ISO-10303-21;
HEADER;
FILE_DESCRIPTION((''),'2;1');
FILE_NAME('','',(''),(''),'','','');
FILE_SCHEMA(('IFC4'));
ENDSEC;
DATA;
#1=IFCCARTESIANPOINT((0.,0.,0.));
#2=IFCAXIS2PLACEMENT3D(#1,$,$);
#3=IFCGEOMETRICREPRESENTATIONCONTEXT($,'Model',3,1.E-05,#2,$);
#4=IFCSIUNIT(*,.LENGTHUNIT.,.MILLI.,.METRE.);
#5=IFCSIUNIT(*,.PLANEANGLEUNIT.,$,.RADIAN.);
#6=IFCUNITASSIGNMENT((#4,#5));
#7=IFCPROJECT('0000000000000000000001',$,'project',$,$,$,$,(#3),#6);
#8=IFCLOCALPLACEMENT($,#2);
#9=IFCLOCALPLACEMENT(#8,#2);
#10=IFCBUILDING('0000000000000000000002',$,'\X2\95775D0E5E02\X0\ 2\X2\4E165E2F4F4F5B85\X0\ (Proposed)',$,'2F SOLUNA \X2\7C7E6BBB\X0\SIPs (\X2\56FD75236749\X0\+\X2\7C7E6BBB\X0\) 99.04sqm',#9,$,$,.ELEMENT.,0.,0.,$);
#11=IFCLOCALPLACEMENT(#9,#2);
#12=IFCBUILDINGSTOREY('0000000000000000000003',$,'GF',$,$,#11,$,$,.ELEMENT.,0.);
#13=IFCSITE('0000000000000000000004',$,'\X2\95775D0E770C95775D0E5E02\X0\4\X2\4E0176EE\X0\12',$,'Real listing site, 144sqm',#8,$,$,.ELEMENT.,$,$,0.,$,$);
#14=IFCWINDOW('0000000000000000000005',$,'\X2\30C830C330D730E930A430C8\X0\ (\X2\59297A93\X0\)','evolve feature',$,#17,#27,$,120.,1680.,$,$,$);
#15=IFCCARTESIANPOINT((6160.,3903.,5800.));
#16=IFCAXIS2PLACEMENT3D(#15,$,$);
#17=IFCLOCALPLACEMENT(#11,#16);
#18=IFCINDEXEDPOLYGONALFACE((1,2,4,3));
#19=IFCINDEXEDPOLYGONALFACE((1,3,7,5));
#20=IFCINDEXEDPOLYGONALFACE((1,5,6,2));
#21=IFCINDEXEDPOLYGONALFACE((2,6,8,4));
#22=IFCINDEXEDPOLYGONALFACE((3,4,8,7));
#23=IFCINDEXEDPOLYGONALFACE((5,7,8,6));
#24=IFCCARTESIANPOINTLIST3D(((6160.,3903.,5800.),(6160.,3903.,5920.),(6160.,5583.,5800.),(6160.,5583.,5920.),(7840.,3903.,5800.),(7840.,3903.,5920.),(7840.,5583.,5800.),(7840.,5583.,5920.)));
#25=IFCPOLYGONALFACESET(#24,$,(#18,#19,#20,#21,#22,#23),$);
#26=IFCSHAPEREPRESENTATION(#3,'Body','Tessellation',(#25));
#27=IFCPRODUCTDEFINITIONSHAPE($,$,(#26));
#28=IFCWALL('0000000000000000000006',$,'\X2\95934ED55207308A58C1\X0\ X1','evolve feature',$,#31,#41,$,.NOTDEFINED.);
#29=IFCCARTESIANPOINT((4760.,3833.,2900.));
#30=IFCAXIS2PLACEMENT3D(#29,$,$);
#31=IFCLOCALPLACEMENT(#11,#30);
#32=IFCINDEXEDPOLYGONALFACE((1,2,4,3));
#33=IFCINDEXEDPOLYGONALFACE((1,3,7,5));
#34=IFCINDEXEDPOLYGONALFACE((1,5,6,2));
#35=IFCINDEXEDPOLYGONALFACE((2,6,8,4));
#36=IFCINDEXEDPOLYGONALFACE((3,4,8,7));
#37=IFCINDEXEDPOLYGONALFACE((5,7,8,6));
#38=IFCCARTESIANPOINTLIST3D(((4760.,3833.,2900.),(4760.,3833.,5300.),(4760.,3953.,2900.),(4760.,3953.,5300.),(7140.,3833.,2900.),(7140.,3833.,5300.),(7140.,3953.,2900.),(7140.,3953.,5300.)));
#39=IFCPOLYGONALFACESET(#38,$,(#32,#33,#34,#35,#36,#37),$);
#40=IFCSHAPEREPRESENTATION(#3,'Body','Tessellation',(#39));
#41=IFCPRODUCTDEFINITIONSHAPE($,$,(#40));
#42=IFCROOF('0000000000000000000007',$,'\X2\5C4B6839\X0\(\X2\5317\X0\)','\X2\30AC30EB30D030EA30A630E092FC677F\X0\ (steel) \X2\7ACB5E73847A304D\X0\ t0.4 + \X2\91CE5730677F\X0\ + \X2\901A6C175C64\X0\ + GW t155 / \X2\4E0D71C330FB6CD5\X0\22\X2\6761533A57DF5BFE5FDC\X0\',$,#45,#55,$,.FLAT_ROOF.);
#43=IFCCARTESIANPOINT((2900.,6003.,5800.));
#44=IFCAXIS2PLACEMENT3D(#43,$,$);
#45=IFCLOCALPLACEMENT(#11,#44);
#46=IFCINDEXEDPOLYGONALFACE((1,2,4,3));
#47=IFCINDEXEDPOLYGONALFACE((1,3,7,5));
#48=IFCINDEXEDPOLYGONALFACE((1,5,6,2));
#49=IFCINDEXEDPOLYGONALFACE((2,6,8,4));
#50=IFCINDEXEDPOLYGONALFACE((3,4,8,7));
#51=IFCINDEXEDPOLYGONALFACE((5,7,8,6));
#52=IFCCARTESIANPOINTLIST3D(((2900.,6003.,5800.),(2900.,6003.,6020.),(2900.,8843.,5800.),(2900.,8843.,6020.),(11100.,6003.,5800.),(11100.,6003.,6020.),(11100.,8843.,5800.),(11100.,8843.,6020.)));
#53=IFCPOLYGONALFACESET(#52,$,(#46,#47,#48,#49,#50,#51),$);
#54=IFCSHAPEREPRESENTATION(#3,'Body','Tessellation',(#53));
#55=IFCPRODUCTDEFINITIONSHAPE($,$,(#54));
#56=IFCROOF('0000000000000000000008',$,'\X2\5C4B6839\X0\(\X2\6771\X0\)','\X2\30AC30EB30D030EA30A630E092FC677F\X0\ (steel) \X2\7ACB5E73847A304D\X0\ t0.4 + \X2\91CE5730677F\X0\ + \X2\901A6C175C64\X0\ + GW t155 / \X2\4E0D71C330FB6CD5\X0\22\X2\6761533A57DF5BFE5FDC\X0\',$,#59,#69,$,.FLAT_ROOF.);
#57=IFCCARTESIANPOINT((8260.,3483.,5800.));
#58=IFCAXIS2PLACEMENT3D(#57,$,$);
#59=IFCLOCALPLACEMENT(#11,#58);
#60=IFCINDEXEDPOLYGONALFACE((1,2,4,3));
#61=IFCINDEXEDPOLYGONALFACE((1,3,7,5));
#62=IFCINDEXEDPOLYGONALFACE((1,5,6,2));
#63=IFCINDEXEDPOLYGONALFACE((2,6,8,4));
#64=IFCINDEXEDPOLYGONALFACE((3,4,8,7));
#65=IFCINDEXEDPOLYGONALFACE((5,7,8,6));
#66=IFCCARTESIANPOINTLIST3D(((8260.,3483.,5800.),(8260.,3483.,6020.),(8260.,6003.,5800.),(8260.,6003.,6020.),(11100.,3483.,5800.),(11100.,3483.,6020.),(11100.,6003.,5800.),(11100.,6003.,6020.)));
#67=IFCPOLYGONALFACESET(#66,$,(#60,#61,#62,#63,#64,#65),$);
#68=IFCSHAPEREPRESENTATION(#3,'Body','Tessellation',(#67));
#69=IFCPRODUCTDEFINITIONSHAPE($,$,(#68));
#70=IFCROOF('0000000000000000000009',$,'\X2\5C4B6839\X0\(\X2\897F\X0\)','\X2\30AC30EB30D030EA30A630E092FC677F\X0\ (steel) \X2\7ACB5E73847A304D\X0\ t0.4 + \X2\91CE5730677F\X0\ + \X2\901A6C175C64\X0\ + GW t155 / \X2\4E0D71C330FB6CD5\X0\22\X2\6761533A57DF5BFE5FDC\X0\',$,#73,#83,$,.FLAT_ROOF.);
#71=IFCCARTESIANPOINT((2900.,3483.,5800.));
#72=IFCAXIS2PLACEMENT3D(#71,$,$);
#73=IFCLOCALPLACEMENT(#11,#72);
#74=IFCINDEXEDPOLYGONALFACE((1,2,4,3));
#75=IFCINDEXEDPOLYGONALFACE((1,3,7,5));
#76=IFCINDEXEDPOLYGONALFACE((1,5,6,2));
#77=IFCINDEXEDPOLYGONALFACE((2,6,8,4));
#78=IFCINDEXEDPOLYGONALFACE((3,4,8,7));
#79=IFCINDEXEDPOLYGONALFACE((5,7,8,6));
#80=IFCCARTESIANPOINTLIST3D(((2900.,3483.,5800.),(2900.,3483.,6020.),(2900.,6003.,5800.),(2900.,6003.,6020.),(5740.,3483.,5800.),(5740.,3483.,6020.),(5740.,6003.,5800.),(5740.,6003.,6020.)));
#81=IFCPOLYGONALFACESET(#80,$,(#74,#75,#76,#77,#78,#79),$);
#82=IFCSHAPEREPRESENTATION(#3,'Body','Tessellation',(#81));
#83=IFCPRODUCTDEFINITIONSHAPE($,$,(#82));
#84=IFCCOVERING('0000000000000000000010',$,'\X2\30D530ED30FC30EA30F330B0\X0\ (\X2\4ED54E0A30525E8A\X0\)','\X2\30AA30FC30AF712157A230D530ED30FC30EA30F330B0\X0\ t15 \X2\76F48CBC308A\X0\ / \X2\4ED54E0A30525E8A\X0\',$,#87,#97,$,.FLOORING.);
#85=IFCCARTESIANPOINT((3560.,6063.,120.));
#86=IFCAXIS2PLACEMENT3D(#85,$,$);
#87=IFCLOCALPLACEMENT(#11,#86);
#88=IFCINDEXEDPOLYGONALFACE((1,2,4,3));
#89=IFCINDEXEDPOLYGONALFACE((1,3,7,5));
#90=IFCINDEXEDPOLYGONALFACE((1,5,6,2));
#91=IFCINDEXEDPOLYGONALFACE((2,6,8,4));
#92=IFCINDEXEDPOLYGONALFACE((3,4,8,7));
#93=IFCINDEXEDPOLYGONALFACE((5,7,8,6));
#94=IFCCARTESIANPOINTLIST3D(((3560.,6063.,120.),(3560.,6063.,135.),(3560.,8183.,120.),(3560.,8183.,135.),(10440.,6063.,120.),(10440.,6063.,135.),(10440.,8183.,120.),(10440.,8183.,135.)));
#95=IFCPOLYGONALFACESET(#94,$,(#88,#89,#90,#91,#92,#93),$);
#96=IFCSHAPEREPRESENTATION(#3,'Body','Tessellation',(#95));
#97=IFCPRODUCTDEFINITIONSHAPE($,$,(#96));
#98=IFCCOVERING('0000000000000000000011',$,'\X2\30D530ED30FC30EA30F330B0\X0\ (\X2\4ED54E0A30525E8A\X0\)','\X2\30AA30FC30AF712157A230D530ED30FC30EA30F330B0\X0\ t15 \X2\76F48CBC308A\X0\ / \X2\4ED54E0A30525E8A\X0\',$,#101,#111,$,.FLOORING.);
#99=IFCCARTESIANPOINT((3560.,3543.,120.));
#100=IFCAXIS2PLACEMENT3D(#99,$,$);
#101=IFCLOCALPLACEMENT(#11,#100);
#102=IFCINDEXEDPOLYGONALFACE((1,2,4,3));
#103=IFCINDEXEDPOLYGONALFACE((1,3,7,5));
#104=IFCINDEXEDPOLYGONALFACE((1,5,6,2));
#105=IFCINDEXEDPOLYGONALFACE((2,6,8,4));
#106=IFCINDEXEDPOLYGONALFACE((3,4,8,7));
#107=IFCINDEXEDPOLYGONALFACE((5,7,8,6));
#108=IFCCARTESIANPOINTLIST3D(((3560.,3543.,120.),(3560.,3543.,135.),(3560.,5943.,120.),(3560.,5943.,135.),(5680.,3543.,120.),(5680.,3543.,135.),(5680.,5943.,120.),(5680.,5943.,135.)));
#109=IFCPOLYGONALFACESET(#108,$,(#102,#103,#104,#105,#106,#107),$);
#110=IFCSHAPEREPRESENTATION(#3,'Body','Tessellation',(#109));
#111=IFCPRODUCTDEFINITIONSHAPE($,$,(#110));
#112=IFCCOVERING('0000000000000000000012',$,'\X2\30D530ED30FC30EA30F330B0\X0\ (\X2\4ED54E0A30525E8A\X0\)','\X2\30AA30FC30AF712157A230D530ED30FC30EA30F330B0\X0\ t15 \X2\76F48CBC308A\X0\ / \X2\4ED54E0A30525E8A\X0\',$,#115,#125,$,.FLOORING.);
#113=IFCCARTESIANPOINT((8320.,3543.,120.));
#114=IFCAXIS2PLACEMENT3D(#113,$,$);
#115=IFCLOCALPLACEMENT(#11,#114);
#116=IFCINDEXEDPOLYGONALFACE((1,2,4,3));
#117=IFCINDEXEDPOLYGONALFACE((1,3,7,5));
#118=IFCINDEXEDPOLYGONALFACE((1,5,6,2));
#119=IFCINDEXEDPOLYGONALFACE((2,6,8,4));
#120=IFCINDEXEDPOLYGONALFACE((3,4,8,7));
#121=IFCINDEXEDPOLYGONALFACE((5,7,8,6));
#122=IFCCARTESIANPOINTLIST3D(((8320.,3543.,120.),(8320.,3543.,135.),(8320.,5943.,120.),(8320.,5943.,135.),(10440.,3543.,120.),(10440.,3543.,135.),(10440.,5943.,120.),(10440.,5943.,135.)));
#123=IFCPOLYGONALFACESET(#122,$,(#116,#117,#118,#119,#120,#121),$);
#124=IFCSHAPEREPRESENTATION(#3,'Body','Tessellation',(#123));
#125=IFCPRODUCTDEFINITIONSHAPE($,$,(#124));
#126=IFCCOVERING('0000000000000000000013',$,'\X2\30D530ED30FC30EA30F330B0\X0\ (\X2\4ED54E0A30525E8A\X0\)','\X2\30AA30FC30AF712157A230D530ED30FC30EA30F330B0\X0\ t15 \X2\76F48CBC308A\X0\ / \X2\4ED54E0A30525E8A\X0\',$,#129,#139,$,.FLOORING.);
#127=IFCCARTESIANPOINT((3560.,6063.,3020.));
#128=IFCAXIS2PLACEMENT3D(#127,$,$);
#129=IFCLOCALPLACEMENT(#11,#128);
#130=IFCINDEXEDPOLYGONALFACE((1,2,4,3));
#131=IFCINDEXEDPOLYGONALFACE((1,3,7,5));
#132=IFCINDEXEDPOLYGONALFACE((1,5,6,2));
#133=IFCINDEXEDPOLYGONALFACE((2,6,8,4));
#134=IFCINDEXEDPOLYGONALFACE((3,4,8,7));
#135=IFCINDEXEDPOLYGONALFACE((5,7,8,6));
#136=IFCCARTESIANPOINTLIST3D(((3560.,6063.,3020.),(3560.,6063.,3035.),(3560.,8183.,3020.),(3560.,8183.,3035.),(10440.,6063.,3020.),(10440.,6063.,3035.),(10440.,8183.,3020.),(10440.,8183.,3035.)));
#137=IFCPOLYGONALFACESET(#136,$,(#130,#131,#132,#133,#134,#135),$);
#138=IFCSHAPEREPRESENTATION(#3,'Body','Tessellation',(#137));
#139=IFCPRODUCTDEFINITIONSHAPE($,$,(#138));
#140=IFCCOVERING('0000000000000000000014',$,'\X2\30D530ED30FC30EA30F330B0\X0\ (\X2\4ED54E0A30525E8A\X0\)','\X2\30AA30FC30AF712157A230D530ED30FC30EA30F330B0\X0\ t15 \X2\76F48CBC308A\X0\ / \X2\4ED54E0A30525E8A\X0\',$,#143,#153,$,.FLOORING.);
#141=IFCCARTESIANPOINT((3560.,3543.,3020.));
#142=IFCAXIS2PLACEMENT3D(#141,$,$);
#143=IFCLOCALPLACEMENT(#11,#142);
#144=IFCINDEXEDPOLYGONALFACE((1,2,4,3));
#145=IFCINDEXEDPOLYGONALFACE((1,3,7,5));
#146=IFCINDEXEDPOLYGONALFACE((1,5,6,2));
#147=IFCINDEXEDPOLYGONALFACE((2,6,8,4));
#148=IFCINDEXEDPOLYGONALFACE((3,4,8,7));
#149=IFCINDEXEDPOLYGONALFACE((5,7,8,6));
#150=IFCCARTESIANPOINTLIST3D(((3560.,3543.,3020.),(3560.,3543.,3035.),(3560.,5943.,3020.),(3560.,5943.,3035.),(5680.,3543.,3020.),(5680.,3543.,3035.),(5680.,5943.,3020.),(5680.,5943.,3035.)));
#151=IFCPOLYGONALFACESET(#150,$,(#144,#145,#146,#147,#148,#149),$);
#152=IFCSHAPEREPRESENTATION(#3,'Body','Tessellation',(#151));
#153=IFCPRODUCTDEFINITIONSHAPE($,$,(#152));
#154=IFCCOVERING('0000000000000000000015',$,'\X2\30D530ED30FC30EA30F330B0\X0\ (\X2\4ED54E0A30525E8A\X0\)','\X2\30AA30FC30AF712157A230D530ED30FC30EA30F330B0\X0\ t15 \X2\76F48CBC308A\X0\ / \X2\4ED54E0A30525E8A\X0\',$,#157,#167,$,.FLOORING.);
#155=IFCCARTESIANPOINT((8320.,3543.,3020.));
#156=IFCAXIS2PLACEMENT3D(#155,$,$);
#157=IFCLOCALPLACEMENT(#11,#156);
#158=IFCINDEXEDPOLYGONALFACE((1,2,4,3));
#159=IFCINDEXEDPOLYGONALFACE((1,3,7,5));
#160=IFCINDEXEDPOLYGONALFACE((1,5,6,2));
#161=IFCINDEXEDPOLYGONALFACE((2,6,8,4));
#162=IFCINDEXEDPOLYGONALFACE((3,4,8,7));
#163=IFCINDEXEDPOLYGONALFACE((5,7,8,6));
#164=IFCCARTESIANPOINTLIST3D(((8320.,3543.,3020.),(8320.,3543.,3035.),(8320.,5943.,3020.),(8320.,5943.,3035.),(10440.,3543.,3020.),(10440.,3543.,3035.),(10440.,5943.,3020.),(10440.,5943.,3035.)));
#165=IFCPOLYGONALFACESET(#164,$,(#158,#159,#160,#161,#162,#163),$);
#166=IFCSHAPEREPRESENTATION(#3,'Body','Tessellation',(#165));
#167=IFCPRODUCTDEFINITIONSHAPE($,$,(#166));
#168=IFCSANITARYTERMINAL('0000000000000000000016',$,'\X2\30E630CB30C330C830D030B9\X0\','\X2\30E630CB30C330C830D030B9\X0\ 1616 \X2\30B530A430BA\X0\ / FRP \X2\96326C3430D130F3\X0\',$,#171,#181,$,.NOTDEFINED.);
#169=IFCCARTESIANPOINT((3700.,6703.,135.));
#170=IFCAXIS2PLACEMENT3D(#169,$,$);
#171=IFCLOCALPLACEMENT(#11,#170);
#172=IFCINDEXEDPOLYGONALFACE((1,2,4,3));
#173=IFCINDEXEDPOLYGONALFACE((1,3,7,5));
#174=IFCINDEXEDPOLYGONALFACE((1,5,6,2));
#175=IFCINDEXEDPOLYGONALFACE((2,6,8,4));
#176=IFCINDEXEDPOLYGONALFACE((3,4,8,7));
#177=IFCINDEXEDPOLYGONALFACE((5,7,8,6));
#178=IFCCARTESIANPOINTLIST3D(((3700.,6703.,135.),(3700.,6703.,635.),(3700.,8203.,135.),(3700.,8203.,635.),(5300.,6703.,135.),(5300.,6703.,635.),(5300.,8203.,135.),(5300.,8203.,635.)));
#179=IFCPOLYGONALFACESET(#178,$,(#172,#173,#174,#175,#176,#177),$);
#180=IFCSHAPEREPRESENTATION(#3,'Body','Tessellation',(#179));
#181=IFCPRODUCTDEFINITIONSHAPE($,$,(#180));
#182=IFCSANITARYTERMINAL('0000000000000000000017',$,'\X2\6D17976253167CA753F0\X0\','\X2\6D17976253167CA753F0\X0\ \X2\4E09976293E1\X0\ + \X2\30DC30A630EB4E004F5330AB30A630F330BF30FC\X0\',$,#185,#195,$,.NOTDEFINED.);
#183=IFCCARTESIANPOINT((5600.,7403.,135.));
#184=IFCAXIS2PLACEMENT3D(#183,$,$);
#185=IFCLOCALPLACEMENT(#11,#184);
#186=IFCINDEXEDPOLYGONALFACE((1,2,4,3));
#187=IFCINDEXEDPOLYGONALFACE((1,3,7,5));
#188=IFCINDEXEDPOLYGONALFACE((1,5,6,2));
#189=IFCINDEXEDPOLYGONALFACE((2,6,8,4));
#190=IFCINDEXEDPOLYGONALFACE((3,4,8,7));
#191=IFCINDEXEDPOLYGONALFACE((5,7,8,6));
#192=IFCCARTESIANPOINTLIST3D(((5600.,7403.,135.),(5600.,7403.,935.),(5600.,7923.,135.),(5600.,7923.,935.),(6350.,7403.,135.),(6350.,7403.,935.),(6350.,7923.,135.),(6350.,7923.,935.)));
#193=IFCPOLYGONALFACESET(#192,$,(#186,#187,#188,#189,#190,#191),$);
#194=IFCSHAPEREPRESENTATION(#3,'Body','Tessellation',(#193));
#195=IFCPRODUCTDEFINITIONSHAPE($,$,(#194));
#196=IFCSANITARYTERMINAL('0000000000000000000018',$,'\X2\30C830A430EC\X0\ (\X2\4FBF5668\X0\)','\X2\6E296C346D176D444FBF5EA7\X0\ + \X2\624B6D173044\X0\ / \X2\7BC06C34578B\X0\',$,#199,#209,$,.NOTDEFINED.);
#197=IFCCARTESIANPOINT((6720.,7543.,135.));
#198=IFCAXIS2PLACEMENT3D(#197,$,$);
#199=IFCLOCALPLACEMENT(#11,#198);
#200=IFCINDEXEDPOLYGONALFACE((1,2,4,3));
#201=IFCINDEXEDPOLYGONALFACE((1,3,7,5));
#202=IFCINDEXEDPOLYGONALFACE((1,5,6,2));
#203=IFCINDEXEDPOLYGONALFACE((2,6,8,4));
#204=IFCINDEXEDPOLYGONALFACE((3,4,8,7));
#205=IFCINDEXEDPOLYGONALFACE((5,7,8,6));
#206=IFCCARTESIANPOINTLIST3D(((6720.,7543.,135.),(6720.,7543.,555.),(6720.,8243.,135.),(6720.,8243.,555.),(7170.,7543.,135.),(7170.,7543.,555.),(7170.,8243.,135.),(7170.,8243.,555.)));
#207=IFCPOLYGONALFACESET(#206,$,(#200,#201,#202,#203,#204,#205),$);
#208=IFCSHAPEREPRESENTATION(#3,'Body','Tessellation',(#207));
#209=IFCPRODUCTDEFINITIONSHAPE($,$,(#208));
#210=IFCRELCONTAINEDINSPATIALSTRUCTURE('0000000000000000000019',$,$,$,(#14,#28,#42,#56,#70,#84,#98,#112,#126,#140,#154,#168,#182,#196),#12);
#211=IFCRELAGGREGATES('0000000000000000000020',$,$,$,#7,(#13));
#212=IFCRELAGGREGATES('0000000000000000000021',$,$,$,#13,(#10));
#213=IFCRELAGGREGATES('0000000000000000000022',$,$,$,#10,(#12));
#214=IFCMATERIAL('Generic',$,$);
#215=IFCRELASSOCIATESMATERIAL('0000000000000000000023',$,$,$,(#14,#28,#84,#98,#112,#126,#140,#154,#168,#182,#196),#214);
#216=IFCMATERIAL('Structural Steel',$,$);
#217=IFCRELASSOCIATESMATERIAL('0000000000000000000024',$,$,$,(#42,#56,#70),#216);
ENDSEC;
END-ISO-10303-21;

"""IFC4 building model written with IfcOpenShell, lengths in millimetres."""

from ifc_helpers import new_model, si_unit, frame, frame_2d, origin, place, context, project, spatial, rectangle, extrude, material, element, save


model = new_model("IFC4")

# Units and contexts
model_context = context("Model", 3, precision=1e-05, world=origin())
ifc_project = project(units=[si_unit("LENGTHUNIT", "METRE", prefix="MILLI"), si_unit("PLANEANGLEUNIT", "RADIAN")], contexts=[model_context])

# Site, building, storey
site_placement = place(None, origin())
site = spatial("IfcSite", under=ifc_project, at=site_placement, Name="長崎県長崎市4丁目12", ObjectType="Real listing site, 144sqm", CompositionType="ELEMENT", RefElevation=0.0)
building_placement = place(site_placement, origin())
building = spatial("IfcBuilding", under=site, at=building_placement, Name="長崎市 2世帯住宅 (Proposed)", ObjectType="2F SOLUNA 籾殻SIPs (国産杉+籾殻) 99.04sqm", CompositionType="ELEMENT", ElevationOfRefHeight=0.0, ElevationOfTerrain=0.0)
storey_placement = place(building_placement, origin())
storey = spatial("IfcBuildingStorey", under=building, at=storey_placement, Name="GF", CompositionType="ELEMENT", Elevation=0.0)

# Window
ifc_material_1 = material(Name="Generic")
window_1_placement = place(storey_placement, frame((6160.0, 3903.0, 5800.0)))
element("IfcWindow", 1, at=window_1_placement, inside=storey, material=ifc_material_1, Name="トップライト (天窓)", Description="evolve feature", OverallHeight=120.0, OverallWidth=1680.0, context=model_context, shape_type="SweptSolid", body=[
    extrude(rectangle(XDim=1680.0, YDim=1680.0, at=frame_2d((840.0, 840.0))), frame((6160.0, 3903.0, 5800.0)), (0.0, 0.0, 1.0), 120.0),
])

# Wall
wall_1_placement = place(storey_placement, frame((4760.0, 3833.0, 2900.0)))
element("IfcWall", 2, at=wall_1_placement, inside=storey, material=ifc_material_1, Name="間仕切り壁 X1", Description="evolve feature", PredefinedType="NOTDEFINED", context=model_context, shape_type="SweptSolid", body=[
    extrude(rectangle(XDim=2380.0, YDim=120.0, at=frame_2d((1190.0, 60.0))), frame((4760.0, 3833.0, 2900.0)), (0.0, 0.0, 1.0), 2400.0),
])

# Roofs
ifc_material_2 = material(Name="Structural Steel")
roof_1_placement = place(storey_placement, frame((2900.0, 6003.0, 5800.0)))
element("IfcRoof", 3, at=roof_1_placement, inside=storey, material=ifc_material_2, Name="屋根(北)", Description="ガルバリウム鋼板 (steel) 立平葺き t0.4 + 野地板 + 通気層 + GW t155 / 不燃・法22条区域対応", PredefinedType="FLAT_ROOF", context=model_context, shape_type="SweptSolid", body=[
    extrude(rectangle(XDim=8200.0, YDim=2840.0, at=frame_2d((4100.0, 1420.0))), frame((2900.0, 6003.0, 5800.0)), (0.0, 0.0, 1.0), 220.0),
])
roof_2_placement = place(storey_placement, frame((8260.0, 3483.0, 5800.0)))
element("IfcRoof", 4, at=roof_2_placement, inside=storey, material=ifc_material_2, Name="屋根(東)", Description="ガルバリウム鋼板 (steel) 立平葺き t0.4 + 野地板 + 通気層 + GW t155 / 不燃・法22条区域対応", PredefinedType="FLAT_ROOF", context=model_context, shape_type="SweptSolid", body=[
    extrude(rectangle(XDim=2840.0, YDim=2520.0, at=frame_2d((1420.0, 1260.0))), frame((8260.0, 3483.0, 5800.0)), (0.0, 0.0, 1.0), 220.0),
])
roof_3_placement = place(storey_placement, frame((2900.0, 3483.0, 5800.0)))
element("IfcRoof", 5, at=roof_3_placement, inside=storey, material=ifc_material_2, Name="屋根(西)", Description="ガルバリウム鋼板 (steel) 立平葺き t0.4 + 野地板 + 通気層 + GW t155 / 不燃・法22条区域対応", PredefinedType="FLAT_ROOF", context=model_context, shape_type="SweptSolid", body=[
    extrude(rectangle(XDim=2840.0, YDim=2520.0, at=frame_2d((1420.0, 1260.0))), frame((2900.0, 3483.0, 5800.0)), (0.0, 0.0, 1.0), 220.0),
])

# Coverings
covering_1_placement = place(storey_placement, frame((3560.0, 6063.0, 120.0)))
element("IfcCovering", 6, at=covering_1_placement, inside=storey, material=ifc_material_1, Name="フローリング (仕上げ床)", Description="オーク無垢フローリング t15 直貼り / 仕上げ床", PredefinedType="FLOORING", context=model_context, shape_type="SweptSolid", body=[
    extrude(rectangle(XDim=6880.0, YDim=2120.0, at=frame_2d((3440.0, 1060.0))), frame((3560.0, 6063.0, 120.0)), (0.0, 0.0, 1.0), 15.0),
])
covering_2_placement = place(storey_placement, frame((3560.0, 3543.0, 120.0)))
element("IfcCovering", 7, at=covering_2_placement, inside=storey, material=ifc_material_1, Name="フローリング (仕上げ床)", Description="オーク無垢フローリング t15 直貼り / 仕上げ床", PredefinedType="FLOORING", context=model_context, shape_type="SweptSolid", body=[
    extrude(rectangle(XDim=2120.0, YDim=2400.0, at=frame_2d((1060.0, 1200.0))), frame((3560.0, 3543.0, 120.0)), (0.0, 0.0, 1.0), 15.0),
])
covering_3_placement = place(storey_placement, frame((8320.0, 3543.0, 120.0)))
element("IfcCovering", 8, at=covering_3_placement, inside=storey, material=ifc_material_1, Name="フローリング (仕上げ床)", Description="オーク無垢フローリング t15 直貼り / 仕上げ床", PredefinedType="FLOORING", context=model_context, shape_type="SweptSolid", body=[
    extrude(rectangle(XDim=2120.0, YDim=2400.0, at=frame_2d((1060.0, 1200.0))), frame((8320.0, 3543.0, 120.0)), (0.0, 0.0, 1.0), 15.0),
])
covering_4_placement = place(storey_placement, frame((3560.0, 6063.0, 3020.0)))
element("IfcCovering", 9, at=covering_4_placement, inside=storey, material=ifc_material_1, Name="フローリング (仕上げ床)", Description="オーク無垢フローリング t15 直貼り / 仕上げ床", PredefinedType="FLOORING", context=model_context, shape_type="SweptSolid", body=[
    extrude(rectangle(XDim=6880.0, YDim=2120.0, at=frame_2d((3440.0, 1060.0))), frame((3560.0, 6063.0, 3020.0)), (0.0, 0.0, 1.0), 15.0),
])
covering_5_placement = place(storey_placement, frame((3560.0, 3543.0, 3020.0)))
element("IfcCovering", 10, at=covering_5_placement, inside=storey, material=ifc_material_1, Name="フローリング (仕上げ床)", Description="オーク無垢フローリング t15 直貼り / 仕上げ床", PredefinedType="FLOORING", context=model_context, shape_type="SweptSolid", body=[
    extrude(rectangle(XDim=2120.0, YDim=2400.0, at=frame_2d((1060.0, 1200.0))), frame((3560.0, 3543.0, 3020.0)), (0.0, 0.0, 1.0), 15.0),
])
covering_6_placement = place(storey_placement, frame((8320.0, 3543.0, 3020.0)))
element("IfcCovering", 11, at=covering_6_placement, inside=storey, material=ifc_material_1, Name="フローリング (仕上げ床)", Description="オーク無垢フローリング t15 直貼り / 仕上げ床", PredefinedType="FLOORING", context=model_context, shape_type="SweptSolid", body=[
    extrude(rectangle(XDim=2120.0, YDim=2400.0, at=frame_2d((1060.0, 1200.0))), frame((8320.0, 3543.0, 3020.0)), (0.0, 0.0, 1.0), 15.0),
])

# Sanitary terminals
sanitary_terminal_1_placement = place(storey_placement, frame((3700.0, 6703.0, 135.0)))
element("IfcSanitaryTerminal", 12, at=sanitary_terminal_1_placement, inside=storey, material=ifc_material_1, Name="ユニットバス", Description="ユニットバス 1616 サイズ / FRP 防水パン", PredefinedType="NOTDEFINED", context=model_context, shape_type="SweptSolid", body=[
    extrude(rectangle(XDim=1600.0, YDim=1500.0, at=frame_2d((800.0, 750.0))), frame((3700.0, 6703.0, 135.0)), (0.0, 0.0, 1.0), 500.0),
])
sanitary_terminal_2_placement = place(storey_placement, frame((5600.0, 7403.0, 135.0)))
element("IfcSanitaryTerminal", 13, at=sanitary_terminal_2_placement, inside=storey, material=ifc_material_1, Name="洗面化粧台", Description="洗面化粧台 三面鏡 + ボウル一体カウンター", PredefinedType="NOTDEFINED", context=model_context, shape_type="SweptSolid", body=[
    extrude(rectangle(XDim=750.0, YDim=520.0, at=frame_2d((375.0, 260.0))), frame((5600.0, 7403.0, 135.0)), (0.0, 0.0, 1.0), 800.0),
])
sanitary_terminal_3_placement = place(storey_placement, frame((6720.0, 7543.0, 135.0)))
element("IfcSanitaryTerminal", 14, at=sanitary_terminal_3_placement, inside=storey, material=ifc_material_1, Name="トイレ (便器)", Description="温水洗浄便座 + 手洗い / 節水型", PredefinedType="NOTDEFINED", context=model_context, shape_type="SweptSolid", body=[
    extrude(rectangle(XDim=450.0, YDim=700.0, at=frame_2d((225.0, 350.0))), frame((6720.0, 7543.0, 135.0)), (0.0, 0.0, 1.0), 420.0),
])

save(model, "model.ifc")
